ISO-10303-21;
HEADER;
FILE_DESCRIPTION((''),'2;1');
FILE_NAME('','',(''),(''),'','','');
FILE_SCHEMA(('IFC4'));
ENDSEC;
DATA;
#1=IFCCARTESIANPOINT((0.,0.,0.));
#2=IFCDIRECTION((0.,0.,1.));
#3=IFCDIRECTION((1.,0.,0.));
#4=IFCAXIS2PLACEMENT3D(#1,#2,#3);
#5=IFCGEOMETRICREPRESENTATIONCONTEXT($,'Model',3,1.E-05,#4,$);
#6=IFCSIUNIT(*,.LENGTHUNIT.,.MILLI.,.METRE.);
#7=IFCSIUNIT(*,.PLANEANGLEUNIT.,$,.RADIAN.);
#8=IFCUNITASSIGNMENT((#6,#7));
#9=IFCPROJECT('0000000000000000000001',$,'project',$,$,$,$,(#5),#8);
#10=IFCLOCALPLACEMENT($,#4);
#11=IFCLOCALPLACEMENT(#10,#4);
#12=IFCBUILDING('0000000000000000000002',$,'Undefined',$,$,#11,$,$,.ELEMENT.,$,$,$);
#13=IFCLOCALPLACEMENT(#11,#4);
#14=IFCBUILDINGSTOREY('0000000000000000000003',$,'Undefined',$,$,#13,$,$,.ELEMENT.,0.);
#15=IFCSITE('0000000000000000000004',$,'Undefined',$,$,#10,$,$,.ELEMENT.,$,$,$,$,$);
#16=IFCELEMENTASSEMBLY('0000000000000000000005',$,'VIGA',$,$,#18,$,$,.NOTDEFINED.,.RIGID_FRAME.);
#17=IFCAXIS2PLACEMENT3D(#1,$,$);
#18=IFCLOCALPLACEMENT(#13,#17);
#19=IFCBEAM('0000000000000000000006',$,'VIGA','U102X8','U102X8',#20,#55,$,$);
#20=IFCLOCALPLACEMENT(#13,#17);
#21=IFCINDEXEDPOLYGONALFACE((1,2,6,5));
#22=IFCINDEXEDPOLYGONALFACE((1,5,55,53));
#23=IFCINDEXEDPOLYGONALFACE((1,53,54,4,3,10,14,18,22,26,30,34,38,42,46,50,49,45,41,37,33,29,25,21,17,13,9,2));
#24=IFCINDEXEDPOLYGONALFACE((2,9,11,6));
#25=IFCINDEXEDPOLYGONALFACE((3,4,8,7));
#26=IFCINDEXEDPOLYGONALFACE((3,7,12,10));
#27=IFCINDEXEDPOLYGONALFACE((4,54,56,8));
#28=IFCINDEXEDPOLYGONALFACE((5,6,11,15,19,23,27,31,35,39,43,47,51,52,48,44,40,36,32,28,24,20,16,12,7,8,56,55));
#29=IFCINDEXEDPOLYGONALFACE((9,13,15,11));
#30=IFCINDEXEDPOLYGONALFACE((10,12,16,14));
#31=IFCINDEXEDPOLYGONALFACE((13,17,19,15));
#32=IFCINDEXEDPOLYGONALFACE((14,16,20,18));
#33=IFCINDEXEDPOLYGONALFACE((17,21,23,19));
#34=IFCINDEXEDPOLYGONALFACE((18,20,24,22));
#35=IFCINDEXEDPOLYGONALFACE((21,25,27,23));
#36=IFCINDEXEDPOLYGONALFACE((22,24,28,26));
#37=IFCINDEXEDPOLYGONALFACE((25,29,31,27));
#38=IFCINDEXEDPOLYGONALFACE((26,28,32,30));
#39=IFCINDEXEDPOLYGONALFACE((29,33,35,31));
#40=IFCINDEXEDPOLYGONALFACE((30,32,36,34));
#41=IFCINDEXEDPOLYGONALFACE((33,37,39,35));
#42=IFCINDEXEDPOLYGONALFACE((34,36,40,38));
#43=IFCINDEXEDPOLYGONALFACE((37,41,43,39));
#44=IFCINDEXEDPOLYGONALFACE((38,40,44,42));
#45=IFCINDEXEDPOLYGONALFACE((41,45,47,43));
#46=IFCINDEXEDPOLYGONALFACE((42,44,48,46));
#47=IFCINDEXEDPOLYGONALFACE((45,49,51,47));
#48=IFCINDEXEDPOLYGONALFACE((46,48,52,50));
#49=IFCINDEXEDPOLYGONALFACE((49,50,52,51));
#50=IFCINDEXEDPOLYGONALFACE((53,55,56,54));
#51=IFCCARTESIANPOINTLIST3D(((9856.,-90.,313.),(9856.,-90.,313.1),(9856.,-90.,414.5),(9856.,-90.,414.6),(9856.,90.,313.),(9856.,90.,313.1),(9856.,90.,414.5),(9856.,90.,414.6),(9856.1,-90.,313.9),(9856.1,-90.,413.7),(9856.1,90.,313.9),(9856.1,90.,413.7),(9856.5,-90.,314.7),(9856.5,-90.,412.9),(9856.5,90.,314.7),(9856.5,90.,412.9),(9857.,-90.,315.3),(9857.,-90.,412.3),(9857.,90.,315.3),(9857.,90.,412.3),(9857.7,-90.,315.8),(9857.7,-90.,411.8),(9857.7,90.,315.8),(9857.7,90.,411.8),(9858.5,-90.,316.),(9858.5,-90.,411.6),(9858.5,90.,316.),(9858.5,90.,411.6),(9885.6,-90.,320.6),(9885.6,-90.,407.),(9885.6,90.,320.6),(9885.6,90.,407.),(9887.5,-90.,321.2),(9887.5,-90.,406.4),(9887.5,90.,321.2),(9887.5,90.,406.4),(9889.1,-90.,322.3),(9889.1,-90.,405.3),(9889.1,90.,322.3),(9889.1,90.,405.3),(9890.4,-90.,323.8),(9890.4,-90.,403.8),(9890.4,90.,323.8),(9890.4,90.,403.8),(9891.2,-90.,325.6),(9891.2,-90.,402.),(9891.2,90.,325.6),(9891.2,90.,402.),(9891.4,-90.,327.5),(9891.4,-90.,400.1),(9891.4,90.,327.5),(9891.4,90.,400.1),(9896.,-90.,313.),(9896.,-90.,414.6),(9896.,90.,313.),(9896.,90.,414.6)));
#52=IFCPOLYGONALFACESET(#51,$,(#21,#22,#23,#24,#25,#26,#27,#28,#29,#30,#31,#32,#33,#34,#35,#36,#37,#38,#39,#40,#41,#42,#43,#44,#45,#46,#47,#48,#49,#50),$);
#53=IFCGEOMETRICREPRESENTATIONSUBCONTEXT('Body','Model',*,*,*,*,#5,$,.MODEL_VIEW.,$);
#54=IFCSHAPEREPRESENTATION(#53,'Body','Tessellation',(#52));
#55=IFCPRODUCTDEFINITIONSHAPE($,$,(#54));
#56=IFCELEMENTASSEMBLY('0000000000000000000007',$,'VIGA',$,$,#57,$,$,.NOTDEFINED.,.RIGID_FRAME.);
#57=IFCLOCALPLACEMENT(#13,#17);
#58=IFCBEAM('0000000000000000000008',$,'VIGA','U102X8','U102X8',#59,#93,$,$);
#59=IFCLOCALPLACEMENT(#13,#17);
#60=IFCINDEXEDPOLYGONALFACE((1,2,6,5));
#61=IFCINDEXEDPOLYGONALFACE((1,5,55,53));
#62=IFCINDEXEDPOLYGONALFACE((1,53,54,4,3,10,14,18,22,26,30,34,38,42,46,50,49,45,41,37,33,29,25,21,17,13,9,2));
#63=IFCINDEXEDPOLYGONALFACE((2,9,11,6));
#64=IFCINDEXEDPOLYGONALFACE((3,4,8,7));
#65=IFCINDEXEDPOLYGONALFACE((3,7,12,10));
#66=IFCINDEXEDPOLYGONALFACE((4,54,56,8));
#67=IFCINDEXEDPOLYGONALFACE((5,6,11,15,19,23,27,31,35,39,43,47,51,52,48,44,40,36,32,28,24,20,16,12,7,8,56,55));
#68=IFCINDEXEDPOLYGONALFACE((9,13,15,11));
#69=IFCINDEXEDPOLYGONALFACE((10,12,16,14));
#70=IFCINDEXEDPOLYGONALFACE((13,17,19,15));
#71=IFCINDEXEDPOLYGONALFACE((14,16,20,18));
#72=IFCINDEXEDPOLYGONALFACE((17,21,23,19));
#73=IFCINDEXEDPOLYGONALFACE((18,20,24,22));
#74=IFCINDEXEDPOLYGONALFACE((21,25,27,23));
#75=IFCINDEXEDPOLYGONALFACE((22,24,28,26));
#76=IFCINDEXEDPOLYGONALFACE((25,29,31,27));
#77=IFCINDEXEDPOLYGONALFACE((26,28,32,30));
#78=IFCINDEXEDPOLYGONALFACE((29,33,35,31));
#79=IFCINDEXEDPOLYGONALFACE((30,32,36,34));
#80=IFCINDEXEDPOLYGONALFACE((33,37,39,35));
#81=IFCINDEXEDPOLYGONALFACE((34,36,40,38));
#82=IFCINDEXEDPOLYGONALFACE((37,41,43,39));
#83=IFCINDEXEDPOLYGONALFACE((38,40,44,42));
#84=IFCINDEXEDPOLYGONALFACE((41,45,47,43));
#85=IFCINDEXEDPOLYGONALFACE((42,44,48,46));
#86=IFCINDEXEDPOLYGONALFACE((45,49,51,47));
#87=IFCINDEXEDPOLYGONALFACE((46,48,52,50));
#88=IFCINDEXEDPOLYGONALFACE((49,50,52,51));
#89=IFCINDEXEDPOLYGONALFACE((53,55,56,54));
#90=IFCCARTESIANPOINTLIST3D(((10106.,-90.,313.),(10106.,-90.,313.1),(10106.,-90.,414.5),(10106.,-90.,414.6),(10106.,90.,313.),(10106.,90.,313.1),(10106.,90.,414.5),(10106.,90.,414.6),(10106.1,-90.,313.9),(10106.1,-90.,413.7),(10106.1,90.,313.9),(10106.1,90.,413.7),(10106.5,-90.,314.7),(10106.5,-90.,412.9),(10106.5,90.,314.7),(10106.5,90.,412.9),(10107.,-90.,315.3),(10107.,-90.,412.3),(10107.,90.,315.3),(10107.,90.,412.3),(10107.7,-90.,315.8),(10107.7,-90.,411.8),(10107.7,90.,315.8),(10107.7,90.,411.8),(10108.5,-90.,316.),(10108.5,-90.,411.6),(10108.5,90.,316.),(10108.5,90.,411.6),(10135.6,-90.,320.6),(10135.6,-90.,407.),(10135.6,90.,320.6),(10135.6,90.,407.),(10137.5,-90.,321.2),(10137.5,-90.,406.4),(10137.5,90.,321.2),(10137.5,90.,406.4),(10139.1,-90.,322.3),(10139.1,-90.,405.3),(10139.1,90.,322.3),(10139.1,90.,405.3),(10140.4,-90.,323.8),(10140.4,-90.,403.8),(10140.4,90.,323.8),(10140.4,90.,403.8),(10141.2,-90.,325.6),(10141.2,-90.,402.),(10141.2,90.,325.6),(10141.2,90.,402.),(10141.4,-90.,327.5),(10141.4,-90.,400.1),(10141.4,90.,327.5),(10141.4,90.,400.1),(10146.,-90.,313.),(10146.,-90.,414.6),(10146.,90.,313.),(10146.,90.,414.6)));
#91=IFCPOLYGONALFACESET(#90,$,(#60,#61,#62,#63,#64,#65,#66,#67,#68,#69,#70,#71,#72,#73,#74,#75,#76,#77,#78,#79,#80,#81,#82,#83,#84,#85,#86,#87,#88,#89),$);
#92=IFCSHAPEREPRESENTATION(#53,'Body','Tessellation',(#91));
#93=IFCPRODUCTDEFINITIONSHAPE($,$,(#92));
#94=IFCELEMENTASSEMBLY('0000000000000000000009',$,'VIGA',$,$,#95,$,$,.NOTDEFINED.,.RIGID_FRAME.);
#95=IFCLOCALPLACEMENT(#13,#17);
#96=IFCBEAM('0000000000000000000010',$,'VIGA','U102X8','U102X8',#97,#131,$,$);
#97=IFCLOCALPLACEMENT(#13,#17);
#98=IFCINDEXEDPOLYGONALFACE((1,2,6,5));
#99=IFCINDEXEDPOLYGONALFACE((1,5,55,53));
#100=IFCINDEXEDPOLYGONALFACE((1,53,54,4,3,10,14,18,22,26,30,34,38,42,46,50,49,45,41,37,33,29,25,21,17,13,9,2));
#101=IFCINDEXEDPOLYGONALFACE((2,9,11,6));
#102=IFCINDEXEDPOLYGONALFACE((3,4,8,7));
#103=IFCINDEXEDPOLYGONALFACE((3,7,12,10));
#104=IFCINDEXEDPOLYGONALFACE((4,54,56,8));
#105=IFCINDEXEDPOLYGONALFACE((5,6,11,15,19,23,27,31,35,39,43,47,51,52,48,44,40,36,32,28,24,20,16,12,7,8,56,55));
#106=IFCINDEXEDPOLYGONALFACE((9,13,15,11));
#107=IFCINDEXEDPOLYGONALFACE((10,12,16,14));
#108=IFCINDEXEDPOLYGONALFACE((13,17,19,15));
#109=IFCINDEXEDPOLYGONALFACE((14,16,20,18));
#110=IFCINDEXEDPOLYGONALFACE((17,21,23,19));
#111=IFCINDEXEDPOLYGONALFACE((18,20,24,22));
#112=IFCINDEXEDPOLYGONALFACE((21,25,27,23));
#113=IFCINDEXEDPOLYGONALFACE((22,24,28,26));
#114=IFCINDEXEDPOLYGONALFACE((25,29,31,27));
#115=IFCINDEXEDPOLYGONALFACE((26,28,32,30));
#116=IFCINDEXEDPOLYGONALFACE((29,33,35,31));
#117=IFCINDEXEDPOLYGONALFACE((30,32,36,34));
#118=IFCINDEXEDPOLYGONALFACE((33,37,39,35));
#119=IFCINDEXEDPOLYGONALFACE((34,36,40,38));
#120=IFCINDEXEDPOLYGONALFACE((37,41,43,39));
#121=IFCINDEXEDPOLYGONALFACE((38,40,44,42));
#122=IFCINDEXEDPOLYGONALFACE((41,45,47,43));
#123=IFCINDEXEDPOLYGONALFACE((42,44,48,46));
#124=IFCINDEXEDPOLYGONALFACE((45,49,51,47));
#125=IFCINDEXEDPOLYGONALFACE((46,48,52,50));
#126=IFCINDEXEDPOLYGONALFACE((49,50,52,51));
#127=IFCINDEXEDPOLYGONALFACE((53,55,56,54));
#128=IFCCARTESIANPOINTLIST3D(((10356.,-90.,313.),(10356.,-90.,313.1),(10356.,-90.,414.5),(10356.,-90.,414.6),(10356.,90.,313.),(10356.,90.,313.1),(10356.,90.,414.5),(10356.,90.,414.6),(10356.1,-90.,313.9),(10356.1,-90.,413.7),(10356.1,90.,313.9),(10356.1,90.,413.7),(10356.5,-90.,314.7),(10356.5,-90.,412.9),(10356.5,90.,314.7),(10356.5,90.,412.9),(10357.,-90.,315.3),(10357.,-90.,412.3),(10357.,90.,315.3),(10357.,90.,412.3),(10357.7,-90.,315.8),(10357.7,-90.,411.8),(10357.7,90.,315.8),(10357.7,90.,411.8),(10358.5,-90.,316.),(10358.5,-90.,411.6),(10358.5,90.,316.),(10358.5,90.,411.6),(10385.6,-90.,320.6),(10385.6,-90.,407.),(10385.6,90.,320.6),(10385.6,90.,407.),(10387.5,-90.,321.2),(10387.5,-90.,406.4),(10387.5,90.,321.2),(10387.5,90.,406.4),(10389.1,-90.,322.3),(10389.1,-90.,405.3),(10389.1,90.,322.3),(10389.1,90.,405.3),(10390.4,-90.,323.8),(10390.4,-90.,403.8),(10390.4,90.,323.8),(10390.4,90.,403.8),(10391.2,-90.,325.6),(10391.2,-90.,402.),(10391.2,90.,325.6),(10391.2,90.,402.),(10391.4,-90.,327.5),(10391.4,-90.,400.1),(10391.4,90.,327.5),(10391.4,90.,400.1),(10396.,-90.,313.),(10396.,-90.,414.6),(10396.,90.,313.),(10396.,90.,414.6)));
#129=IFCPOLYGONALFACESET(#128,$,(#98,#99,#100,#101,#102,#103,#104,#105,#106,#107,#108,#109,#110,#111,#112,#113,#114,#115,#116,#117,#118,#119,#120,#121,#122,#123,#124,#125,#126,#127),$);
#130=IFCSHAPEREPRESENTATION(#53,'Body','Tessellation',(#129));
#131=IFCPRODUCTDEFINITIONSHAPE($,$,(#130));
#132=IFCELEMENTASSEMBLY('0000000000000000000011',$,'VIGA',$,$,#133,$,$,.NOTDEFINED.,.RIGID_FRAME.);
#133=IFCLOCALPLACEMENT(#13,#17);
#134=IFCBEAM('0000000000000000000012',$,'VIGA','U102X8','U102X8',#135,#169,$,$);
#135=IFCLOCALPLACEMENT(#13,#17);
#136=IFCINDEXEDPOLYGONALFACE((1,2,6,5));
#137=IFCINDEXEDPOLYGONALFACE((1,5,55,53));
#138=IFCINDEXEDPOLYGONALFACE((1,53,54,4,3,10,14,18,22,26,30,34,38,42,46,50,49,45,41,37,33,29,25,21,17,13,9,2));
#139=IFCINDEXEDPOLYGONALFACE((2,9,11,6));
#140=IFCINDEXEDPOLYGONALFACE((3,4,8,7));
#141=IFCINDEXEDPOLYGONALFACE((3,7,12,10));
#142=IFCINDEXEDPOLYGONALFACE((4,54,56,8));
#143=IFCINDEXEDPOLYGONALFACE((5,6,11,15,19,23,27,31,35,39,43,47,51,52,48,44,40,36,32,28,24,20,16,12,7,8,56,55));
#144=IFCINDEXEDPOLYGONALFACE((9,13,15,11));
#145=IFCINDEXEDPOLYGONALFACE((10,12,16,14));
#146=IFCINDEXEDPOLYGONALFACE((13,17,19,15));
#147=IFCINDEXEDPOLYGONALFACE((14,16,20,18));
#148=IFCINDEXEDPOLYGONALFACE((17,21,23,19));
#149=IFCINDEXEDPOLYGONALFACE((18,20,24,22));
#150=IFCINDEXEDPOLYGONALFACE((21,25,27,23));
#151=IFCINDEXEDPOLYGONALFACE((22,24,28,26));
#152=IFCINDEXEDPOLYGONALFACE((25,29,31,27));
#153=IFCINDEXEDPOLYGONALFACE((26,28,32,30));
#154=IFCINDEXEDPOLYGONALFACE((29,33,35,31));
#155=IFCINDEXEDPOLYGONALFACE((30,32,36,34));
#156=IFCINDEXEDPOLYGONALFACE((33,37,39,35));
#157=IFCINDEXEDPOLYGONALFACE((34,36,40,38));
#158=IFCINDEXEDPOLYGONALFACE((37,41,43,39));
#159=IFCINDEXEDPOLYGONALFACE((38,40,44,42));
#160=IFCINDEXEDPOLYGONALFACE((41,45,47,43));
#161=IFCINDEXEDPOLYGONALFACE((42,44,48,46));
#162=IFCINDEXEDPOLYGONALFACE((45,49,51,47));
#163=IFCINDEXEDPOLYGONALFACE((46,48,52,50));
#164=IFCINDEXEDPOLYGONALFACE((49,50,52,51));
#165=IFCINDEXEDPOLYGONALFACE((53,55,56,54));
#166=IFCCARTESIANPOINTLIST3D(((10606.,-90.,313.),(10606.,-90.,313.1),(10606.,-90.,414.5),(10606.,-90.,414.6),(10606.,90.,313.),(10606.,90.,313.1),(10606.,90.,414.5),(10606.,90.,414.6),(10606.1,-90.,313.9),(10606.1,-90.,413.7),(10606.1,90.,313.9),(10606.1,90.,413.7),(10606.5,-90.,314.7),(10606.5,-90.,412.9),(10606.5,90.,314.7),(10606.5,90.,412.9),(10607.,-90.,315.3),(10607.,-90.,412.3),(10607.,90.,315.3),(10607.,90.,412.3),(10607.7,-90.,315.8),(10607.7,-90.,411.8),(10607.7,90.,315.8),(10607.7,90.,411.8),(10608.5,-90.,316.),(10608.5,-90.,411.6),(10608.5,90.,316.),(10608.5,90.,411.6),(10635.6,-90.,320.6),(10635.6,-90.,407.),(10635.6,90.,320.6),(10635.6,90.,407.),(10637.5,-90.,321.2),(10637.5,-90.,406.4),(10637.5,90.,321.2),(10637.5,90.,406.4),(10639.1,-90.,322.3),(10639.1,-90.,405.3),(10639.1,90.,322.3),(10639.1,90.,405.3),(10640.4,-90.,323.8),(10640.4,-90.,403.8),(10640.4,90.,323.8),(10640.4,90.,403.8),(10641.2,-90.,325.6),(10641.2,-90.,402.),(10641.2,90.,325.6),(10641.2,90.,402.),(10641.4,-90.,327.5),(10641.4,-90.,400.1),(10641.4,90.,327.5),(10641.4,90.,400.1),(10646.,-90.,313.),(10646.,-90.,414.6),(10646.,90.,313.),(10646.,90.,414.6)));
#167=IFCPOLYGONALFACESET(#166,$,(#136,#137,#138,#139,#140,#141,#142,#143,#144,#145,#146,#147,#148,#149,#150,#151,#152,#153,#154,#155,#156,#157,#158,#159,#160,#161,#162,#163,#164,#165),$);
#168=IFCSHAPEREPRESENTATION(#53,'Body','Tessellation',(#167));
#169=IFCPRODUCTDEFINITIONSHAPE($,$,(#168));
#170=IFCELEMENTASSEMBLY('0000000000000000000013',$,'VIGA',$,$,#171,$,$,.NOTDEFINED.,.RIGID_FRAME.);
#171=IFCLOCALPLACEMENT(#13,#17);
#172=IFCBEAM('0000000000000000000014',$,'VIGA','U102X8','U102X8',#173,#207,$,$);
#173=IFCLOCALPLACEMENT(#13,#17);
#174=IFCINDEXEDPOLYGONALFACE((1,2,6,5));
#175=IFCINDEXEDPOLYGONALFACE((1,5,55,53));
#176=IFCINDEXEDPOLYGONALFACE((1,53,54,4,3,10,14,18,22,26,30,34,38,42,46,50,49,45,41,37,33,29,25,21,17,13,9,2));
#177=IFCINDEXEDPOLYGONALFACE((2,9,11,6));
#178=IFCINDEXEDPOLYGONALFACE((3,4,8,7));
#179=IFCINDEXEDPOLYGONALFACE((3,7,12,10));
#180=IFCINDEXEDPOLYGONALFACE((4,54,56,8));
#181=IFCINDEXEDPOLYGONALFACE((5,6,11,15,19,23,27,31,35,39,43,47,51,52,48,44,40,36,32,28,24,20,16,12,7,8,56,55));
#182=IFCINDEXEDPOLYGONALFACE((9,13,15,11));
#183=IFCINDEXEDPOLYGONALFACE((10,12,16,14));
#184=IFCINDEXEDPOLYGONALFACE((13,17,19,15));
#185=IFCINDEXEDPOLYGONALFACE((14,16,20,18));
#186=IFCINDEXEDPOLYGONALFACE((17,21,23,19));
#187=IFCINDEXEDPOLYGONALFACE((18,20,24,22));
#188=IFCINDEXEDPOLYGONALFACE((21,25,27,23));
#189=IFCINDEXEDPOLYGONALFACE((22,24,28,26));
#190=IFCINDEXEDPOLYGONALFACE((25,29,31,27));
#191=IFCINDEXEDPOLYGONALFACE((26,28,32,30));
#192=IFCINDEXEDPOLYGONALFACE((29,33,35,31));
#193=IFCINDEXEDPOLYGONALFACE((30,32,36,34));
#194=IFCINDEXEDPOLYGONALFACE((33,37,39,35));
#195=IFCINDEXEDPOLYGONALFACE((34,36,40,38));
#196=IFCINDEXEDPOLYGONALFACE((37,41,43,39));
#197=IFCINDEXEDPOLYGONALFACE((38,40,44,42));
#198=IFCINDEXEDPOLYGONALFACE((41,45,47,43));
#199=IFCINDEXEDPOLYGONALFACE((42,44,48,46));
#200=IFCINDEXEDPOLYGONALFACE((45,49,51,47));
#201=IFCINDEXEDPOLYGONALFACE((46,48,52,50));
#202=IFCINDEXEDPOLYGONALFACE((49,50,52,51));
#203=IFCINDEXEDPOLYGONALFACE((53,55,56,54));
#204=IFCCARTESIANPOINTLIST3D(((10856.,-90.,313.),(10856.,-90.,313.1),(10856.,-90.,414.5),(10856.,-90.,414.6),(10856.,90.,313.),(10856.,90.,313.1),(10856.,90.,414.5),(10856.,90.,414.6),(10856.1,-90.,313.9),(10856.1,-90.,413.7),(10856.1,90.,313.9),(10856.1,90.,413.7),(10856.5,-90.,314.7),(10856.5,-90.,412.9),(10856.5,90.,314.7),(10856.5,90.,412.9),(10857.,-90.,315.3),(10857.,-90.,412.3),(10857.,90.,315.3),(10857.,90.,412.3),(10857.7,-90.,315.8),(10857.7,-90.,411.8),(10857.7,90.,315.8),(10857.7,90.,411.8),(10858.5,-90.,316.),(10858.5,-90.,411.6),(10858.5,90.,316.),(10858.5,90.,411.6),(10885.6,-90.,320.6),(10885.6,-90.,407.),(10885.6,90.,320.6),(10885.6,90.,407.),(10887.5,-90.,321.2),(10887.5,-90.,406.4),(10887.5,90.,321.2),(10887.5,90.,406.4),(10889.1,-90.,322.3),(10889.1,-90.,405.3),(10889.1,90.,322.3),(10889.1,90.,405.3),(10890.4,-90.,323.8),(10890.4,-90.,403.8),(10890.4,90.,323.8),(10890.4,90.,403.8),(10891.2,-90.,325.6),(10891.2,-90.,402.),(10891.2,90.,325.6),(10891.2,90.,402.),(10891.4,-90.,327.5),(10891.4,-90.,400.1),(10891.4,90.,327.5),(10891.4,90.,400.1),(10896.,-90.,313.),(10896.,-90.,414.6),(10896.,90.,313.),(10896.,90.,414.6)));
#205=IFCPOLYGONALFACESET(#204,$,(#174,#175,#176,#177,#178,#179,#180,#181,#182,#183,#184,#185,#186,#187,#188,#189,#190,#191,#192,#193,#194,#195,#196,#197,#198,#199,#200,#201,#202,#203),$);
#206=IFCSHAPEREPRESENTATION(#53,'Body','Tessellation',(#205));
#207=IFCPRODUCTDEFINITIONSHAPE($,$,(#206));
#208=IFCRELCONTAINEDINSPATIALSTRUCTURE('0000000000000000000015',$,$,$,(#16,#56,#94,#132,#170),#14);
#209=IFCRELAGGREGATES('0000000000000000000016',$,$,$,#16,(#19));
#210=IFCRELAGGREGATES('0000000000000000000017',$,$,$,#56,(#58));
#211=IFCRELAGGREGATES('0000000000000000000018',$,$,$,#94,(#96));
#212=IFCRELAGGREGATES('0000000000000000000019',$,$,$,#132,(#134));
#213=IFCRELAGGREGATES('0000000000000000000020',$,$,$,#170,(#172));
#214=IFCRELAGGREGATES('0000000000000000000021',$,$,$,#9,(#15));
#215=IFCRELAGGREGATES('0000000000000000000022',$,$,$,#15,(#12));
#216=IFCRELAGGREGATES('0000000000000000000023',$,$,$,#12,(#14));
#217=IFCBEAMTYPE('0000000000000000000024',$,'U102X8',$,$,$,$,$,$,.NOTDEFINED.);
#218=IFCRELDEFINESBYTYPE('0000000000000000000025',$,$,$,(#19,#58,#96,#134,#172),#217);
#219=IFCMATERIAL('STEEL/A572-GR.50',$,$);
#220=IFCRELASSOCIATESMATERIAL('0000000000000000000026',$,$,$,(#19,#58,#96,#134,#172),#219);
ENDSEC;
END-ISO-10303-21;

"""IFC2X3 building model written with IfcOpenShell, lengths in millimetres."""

from ifc_helpers import new_model, si_unit, frame, origin_with_axes, origin_2d_with_axis, place, context, subcontext, project, spatial, u_section, extrude, material, type_object, element, aggregate, save


model = new_model("IFC2X3")

# Units and contexts
model_context = context("Model", 3, precision=1e-05, world=origin_with_axes())
body_context = subcontext(model_context, "Body", "Model", "MODEL_VIEW")
ifc_project = project(units=[si_unit("LENGTHUNIT", "METRE", prefix="MILLI"), si_unit("PLANEANGLEUNIT", "RADIAN")], contexts=[model_context])

# Site, building, storey
site_placement = place(None, origin_with_axes())
site = spatial("IfcSite", under=ifc_project, at=site_placement, Name="Undefined", CompositionType="ELEMENT")
building_placement = place(site_placement, origin_with_axes())
building = spatial("IfcBuilding", under=site, at=building_placement, Name="Undefined", CompositionType="ELEMENT")
storey_placement = place(building_placement, origin_with_axes())
storey = spatial("IfcBuildingStorey", under=building, at=storey_placement, Name="Undefined", CompositionType="ELEMENT", Elevation=0.0)

# Element assemblies, beams
ifc_material_1 = material(Name="STEEL/A572-GR.50")
beam_type_1 = type_object("IfcBeamType", Name="U102X8", PredefinedType="NOTDEFINED")
assembly_1_placement = place(storey_placement, origin_with_axes())
assembly_1 = element("IfcElementAssembly", 1, at=assembly_1_placement, inside=storey, Name="VIGA", AssemblyPlace="NOTDEFINED", PredefinedType="RIGID_FRAME")
beam_1_placement = place(assembly_1_placement, frame((9876.0, 90.0, 363.8), z_axis=(0.0, 0.0, 1.0), x_axis=(0.0, -1.0, 0.0)))
beam_1 = element("IfcBeam", 2, at=beam_1_placement, type_object=beam_type_1, material=ifc_material_1, Name="VIGA", Description="U102X8", ObjectType="U102X8", context=body_context, shape_type="SweptSolid", body=[
    extrude(u_section(Depth=101.6, FlangeWidth=40.0, WebThickness=4.6, FlangeThickness=6.0, FilletRadius=7.0, EdgeRadius=3.0, FlangeSlope=0.16839, at=origin_2d_with_axis()), frame((180.0, 0.0, 0.0), z_axis=(-1.0, 0.0, 0.0), x_axis=(0.0, -1.0, 0.0)), (0.0, 0.0, 1.0), 180.0),
])
aggregate(assembly_1, [beam_1])
assembly_2_placement = place(storey_placement, origin_with_axes())
assembly_2 = element("IfcElementAssembly", 3, at=assembly_2_placement, inside=storey, Name="VIGA", AssemblyPlace="NOTDEFINED", PredefinedType="RIGID_FRAME")
beam_2_placement = place(assembly_2_placement, frame((10126.0, 90.0, 363.8), z_axis=(0.0, 0.0, 1.0), x_axis=(0.0, -1.0, 0.0)))
beam_2 = element("IfcBeam", 4, at=beam_2_placement, type_object=beam_type_1, material=ifc_material_1, Name="VIGA", Description="U102X8", ObjectType="U102X8", context=body_context, shape_type="SweptSolid", body=[
    extrude(u_section(Depth=101.6, FlangeWidth=40.0, WebThickness=4.6, FlangeThickness=6.0, FilletRadius=7.0, EdgeRadius=3.0, FlangeSlope=0.16839, at=origin_2d_with_axis()), frame((180.0, 0.0, 0.0), z_axis=(-1.0, 0.0, 0.0), x_axis=(0.0, -1.0, 0.0)), (0.0, 0.0, 1.0), 180.0),
])
aggregate(assembly_2, [beam_2])
assembly_3_placement = place(storey_placement, origin_with_axes())
assembly_3 = element("IfcElementAssembly", 5, at=assembly_3_placement, inside=storey, Name="VIGA", AssemblyPlace="NOTDEFINED", PredefinedType="RIGID_FRAME")
beam_3_placement = place(assembly_3_placement, frame((10376.0, 90.0, 363.8), z_axis=(0.0, 0.0, 1.0), x_axis=(0.0, -1.0, 0.0)))
beam_3 = element("IfcBeam", 6, at=beam_3_placement, type_object=beam_type_1, material=ifc_material_1, Name="VIGA", Description="U102X8", ObjectType="U102X8", context=body_context, shape_type="SweptSolid", body=[
    extrude(u_section(Depth=101.6, FlangeWidth=40.0, WebThickness=4.6, FlangeThickness=6.0, FilletRadius=7.0, EdgeRadius=3.0, FlangeSlope=0.16839, at=origin_2d_with_axis()), frame((180.0, 0.0, 0.0), z_axis=(-1.0, 0.0, 0.0), x_axis=(0.0, -1.0, 0.0)), (0.0, 0.0, 1.0), 180.0),
])
aggregate(assembly_3, [beam_3])
assembly_4_placement = place(storey_placement, origin_with_axes())
assembly_4 = element("IfcElementAssembly", 7, at=assembly_4_placement, inside=storey, Name="VIGA", AssemblyPlace="NOTDEFINED", PredefinedType="RIGID_FRAME")
beam_4_placement = place(assembly_4_placement, frame((10626.0, 90.0, 363.8), z_axis=(0.0, 0.0, 1.0), x_axis=(0.0, -1.0, 0.0)))
beam_4 = element("IfcBeam", 8, at=beam_4_placement, type_object=beam_type_1, material=ifc_material_1, Name="VIGA", Description="U102X8", ObjectType="U102X8", context=body_context, shape_type="SweptSolid", body=[
    extrude(u_section(Depth=101.6, FlangeWidth=40.0, WebThickness=4.6, FlangeThickness=6.0, FilletRadius=7.0, EdgeRadius=3.0, FlangeSlope=0.16839, at=origin_2d_with_axis()), frame((180.0, 0.0, 0.0), z_axis=(-1.0, 0.0, 0.0), x_axis=(0.0, -1.0, 0.0)), (0.0, 0.0, 1.0), 180.0),
])
aggregate(assembly_4, [beam_4])
assembly_5_placement = place(storey_placement, origin_with_axes())
assembly_5 = element("IfcElementAssembly", 9, at=assembly_5_placement, inside=storey, Name="VIGA", AssemblyPlace="NOTDEFINED", PredefinedType="RIGID_FRAME")
beam_5_placement = place(assembly_5_placement, frame((10876.0, 90.0, 363.8), z_axis=(0.0, 0.0, 1.0), x_axis=(0.0, -1.0, 0.0)))
beam_5 = element("IfcBeam", 10, at=beam_5_placement, type_object=beam_type_1, material=ifc_material_1, Name="VIGA", Description="U102X8", ObjectType="U102X8", context=body_context, shape_type="SweptSolid", body=[
    extrude(u_section(Depth=101.6, FlangeWidth=40.0, WebThickness=4.6, FlangeThickness=6.0, FilletRadius=7.0, EdgeRadius=3.0, FlangeSlope=0.16839, at=origin_2d_with_axis()), frame((180.0, 0.0, 0.0), z_axis=(-1.0, 0.0, 0.0), x_axis=(0.0, -1.0, 0.0)), (0.0, 0.0, 1.0), 180.0),
])
aggregate(assembly_5, [beam_5])

save(model, "model.ifc")
